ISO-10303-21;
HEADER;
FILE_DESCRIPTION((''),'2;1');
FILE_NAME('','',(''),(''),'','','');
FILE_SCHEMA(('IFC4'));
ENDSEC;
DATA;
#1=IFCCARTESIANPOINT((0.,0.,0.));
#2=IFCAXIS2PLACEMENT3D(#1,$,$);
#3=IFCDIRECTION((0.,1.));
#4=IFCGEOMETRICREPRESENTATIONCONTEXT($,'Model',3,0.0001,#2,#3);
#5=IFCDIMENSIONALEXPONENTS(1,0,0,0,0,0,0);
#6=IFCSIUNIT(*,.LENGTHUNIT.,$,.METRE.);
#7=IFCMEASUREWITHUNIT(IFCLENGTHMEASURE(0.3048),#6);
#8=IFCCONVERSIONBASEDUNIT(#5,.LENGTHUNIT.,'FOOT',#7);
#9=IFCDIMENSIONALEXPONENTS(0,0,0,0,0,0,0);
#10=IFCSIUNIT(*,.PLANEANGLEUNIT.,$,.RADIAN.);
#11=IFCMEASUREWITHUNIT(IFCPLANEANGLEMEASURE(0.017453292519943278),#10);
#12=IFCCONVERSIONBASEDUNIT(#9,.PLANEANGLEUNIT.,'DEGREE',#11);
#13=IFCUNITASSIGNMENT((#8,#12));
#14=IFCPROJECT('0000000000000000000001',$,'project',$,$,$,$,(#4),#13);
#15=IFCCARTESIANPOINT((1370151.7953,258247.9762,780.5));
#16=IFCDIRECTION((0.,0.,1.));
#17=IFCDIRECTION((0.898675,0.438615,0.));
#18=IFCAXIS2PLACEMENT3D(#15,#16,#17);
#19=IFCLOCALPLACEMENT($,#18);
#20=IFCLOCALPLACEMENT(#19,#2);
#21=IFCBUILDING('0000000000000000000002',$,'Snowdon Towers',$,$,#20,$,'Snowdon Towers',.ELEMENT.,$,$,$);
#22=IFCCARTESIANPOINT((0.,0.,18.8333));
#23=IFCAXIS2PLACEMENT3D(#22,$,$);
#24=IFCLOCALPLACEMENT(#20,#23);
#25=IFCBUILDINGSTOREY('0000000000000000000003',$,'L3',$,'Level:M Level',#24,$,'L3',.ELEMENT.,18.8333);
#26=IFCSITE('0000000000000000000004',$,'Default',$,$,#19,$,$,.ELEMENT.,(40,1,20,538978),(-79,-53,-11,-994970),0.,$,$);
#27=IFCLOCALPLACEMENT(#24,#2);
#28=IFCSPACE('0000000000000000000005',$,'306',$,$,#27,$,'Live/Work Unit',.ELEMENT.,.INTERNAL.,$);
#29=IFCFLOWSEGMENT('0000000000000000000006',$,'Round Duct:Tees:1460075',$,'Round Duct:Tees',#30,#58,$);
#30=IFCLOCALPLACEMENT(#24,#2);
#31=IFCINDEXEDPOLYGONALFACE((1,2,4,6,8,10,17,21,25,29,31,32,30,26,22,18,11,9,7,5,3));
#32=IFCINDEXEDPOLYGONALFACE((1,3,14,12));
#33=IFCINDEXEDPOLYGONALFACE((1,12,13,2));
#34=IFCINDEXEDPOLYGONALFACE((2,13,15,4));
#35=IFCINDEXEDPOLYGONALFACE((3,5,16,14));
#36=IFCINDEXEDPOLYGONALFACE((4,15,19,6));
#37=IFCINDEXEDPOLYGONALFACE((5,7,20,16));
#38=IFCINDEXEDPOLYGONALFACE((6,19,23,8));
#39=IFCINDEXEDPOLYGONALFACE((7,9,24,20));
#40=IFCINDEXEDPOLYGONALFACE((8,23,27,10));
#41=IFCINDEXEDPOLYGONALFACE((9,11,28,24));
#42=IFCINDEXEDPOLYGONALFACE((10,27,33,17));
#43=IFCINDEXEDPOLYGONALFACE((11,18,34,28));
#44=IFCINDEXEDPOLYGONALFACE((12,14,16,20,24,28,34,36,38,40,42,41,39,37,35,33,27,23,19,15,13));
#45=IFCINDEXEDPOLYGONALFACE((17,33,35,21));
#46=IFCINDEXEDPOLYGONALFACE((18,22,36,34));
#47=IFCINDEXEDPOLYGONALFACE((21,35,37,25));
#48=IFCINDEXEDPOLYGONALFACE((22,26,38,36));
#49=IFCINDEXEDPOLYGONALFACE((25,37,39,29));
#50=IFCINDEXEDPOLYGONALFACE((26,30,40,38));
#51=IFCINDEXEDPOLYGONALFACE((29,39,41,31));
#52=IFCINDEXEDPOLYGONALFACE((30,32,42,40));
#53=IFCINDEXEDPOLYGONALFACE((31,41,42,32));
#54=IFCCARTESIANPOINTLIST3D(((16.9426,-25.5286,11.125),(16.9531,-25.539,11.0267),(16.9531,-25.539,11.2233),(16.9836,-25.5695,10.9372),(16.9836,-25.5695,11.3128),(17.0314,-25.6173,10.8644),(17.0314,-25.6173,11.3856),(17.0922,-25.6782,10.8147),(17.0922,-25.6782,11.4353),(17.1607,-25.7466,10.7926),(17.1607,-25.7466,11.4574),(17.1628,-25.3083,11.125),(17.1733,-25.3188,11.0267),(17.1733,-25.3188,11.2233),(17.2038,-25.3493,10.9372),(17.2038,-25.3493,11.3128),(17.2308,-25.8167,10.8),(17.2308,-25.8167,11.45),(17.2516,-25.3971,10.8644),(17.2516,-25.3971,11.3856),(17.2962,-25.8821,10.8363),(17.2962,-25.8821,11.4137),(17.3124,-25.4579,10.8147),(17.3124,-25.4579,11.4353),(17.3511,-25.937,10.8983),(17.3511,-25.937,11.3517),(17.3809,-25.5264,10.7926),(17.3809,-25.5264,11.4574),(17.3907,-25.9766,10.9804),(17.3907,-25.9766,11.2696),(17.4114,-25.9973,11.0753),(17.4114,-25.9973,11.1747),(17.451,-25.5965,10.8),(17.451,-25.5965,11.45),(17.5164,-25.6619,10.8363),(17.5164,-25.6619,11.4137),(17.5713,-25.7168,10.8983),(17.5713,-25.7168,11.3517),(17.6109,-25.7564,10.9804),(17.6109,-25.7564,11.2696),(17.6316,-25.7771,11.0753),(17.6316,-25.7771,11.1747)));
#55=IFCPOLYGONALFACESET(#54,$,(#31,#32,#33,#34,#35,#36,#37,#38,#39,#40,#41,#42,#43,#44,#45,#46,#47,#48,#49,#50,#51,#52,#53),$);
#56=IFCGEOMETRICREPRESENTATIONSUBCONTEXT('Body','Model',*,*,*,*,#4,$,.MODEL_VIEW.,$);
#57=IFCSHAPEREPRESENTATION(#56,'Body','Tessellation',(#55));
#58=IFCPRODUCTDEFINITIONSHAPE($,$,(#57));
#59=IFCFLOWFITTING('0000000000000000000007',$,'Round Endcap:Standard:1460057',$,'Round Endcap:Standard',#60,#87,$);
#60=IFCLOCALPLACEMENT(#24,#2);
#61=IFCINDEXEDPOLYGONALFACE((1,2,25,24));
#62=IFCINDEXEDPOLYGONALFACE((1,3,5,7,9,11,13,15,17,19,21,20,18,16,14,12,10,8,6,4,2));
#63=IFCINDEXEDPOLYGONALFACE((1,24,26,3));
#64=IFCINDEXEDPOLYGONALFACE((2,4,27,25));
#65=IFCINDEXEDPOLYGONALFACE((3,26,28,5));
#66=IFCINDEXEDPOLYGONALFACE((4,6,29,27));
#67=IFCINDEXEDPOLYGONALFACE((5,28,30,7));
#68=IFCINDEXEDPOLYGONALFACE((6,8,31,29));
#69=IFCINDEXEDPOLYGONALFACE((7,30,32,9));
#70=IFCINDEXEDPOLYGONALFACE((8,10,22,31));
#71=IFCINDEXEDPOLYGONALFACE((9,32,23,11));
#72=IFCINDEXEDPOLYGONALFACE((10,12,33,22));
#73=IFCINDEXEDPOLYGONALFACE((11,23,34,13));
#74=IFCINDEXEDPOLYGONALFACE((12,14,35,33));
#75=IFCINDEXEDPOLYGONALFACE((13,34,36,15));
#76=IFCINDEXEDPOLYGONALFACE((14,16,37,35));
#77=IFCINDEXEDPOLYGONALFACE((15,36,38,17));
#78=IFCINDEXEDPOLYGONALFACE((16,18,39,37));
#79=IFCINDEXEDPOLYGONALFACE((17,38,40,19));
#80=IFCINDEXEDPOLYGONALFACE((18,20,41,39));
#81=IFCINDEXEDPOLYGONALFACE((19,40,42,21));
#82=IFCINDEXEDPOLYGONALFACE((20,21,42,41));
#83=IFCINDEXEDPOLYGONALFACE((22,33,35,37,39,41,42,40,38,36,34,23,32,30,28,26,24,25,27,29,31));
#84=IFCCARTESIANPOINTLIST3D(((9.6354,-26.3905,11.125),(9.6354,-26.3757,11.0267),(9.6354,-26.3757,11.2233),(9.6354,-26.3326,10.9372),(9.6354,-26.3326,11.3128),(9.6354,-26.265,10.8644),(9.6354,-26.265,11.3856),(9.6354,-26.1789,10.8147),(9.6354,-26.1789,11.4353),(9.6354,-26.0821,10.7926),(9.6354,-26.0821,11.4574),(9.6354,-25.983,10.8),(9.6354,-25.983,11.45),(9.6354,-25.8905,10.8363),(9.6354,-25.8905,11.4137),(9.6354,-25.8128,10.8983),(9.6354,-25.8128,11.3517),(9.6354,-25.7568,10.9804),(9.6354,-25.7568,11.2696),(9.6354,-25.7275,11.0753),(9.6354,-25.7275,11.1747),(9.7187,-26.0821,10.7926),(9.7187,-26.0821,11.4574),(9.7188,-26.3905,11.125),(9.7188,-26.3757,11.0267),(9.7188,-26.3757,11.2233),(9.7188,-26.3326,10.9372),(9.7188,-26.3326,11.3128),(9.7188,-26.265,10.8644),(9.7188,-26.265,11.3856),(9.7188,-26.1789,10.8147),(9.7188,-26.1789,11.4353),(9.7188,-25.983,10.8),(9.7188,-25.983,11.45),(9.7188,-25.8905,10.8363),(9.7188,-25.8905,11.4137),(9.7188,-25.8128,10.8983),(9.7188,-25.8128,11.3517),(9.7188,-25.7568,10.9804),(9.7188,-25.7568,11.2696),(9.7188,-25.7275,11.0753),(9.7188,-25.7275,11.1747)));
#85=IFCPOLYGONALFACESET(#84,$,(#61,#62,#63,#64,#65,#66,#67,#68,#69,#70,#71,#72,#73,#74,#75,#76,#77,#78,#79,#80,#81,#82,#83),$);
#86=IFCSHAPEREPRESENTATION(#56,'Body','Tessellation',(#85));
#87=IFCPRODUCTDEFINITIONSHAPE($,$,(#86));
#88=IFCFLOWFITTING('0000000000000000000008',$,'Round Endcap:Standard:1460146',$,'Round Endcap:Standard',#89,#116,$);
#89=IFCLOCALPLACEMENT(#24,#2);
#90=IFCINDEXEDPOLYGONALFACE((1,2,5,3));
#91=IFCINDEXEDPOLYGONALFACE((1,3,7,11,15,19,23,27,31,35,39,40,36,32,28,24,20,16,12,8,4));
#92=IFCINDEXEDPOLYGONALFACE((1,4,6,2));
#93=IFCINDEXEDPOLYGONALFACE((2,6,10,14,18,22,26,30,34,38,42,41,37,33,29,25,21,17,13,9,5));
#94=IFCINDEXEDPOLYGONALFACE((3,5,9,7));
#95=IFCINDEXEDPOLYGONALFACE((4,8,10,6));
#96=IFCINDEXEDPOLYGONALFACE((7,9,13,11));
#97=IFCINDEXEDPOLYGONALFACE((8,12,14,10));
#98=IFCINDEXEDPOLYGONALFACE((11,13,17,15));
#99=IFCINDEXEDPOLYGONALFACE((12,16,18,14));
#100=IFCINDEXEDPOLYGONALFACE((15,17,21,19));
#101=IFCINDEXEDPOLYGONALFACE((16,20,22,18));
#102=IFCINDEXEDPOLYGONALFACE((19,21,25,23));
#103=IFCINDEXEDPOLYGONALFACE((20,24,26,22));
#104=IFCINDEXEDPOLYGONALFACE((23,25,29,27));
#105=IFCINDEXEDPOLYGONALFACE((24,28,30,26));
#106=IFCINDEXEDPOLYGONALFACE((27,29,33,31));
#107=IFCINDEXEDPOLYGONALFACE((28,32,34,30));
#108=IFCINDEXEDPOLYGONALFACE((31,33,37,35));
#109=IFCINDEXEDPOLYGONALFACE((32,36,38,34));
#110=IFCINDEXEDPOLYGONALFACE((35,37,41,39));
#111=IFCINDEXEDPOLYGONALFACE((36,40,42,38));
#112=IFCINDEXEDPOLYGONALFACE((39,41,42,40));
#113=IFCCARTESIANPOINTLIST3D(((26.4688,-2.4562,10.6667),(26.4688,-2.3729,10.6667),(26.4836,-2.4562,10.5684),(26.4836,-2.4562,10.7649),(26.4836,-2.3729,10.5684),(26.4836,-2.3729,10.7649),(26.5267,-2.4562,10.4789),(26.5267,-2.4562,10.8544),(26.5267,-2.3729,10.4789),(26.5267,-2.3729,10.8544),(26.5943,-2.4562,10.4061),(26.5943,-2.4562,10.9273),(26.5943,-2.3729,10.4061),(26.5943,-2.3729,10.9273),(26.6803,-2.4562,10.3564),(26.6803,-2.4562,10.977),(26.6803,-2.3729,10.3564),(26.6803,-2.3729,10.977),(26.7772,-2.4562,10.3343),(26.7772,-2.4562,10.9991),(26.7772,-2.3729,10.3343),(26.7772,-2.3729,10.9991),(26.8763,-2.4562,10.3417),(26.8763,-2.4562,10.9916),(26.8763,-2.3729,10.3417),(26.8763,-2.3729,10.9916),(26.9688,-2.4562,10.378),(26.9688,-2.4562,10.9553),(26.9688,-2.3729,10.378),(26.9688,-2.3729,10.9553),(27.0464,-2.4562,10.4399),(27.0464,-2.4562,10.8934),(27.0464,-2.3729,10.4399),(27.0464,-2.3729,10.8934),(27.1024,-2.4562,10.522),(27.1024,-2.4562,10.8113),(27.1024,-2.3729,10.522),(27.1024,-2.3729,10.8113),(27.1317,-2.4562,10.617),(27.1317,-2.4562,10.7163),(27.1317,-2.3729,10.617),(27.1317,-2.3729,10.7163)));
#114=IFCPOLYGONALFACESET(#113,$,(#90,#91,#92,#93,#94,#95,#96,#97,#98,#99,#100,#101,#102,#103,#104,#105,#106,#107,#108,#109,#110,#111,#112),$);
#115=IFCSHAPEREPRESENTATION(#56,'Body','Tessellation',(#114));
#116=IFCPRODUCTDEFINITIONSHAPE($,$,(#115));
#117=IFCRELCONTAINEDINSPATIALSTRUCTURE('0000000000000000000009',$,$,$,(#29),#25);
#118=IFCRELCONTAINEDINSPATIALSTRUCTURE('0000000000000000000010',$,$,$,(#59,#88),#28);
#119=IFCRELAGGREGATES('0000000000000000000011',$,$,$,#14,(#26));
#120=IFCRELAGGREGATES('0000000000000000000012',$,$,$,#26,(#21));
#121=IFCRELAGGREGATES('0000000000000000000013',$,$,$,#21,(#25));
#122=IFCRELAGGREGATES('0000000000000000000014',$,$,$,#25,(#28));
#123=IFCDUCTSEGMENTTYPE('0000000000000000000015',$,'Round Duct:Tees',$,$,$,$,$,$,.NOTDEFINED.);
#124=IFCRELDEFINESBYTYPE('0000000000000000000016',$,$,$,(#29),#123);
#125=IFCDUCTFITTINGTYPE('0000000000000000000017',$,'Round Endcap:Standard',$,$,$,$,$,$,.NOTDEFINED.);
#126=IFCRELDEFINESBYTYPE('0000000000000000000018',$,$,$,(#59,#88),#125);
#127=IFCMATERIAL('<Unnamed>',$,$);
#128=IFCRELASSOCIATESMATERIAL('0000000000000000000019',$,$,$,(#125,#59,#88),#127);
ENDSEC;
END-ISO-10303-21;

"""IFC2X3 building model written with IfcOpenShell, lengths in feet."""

from ifc_helpers import new_model, entity, si_unit, converted_unit, direction, frame, frame_2d, origin, origin_2d_with_axis, place, context, subcontext, project, spatial, circle, extrude, source, transform, mapped, material, type_object, type_shapes, element, save


model = new_model("IFC2X3")

# Units and contexts
model_context = context("Model", 3, precision=0.0001, world=origin(), true_north=direction((0.0, 1.0)))
body_context = subcontext(model_context, "Body", "Model", "MODEL_VIEW")
ifc_project = project(units=[converted_unit("LENGTHUNIT", "FOOT", entity("IfcLengthMeasure", 0.3048), si_unit("LENGTHUNIT", "METRE"), dimensions=[1, 0, 0, 0, 0, 0, 0]), converted_unit("PLANEANGLEUNIT", "DEGREE", entity("IfcPlaneAngleMeasure", 0.017453292519943278), si_unit("PLANEANGLEUNIT", "RADIAN"), dimensions=[0, 0, 0, 0, 0, 0, 0])], contexts=[model_context])

# Site, building, storey
site_placement = place(None, frame((1370151.7953, 258247.9762, 780.5), z_axis=(0.0, 0.0, 1.0), x_axis=(0.898675, 0.438615, 0.0)))
site = spatial("IfcSite", under=ifc_project, at=site_placement, Name="Default", CompositionType="ELEMENT", RefLatitude=(40, 1, 20, 538978), RefLongitude=(-79, -53, -11, -994970), RefElevation=0.0)
building_placement = place(site_placement, origin())
building = spatial("IfcBuilding", under=site, at=building_placement, Name="Snowdon Towers", LongName="Snowdon Towers", CompositionType="ELEMENT")
storey_placement = place(building_placement, frame((0.0, 0.0, 18.8333)))
storey = spatial("IfcBuildingStorey", under=building, at=storey_placement, Name="L3", ObjectType="Level:M Level", LongName="L3", CompositionType="ELEMENT", Elevation=18.8333)

# Flow segment
duct_segment_type = type_object("IfcDuctSegmentType", Name="Round Duct:Tees", PredefinedType="NOTDEFINED")
flow_segment_1_placement = place(storey_placement, frame((16.9374, -26.0052, 10.7864)))
element("IfcFlowSegment", 1, at=flow_segment_1_placement, inside=storey, type_object=duct_segment_type, Name="Round Duct:Tees:1460075", ObjectType="Round Duct:Tees", context=body_context, shape_type="SweptSolid", body=[
    extrude(circle(Radius=0.3333, at=origin_2d_with_axis()), frame((0.2409, 0.2409, 0.3386), z_axis=(0.707107, 0.707107, 0.0), x_axis=(-0.707107, 0.707107, 0.0)), (0.0, 0.0, 1.0), 0.3114),
])

# Shared definitions
space_placement = place(storey_placement, origin())
space = spatial("IfcSpace", under=storey, at=space_placement, Name="306", LongName="Live/Work Unit", CompositionType="ELEMENT", InteriorOrExteriorSpace="INTERNAL")

# Flow fittings
ifc_material = material(Name="<Unnamed>")
duct_fitting_type = type_object("IfcDuctFittingType", Name="Round Endcap:Standard", PredefinedType="NOTDEFINED", material=ifc_material)
shared_shape_1 = source(origin(), body_context, "Body", "SweptSolid", [
    extrude(circle(Radius=0.3333, at=frame_2d((0.0, 0.0), x_axis=(1.0, 0.0))), frame((0.0, 0.0, 0.0), z_axis=(1.0, 0.0, 0.0), x_axis=(0.0, 1.0, 0.0)), (0.0, 0.0, 1.0), 0.0833),
])
type_shapes(duct_fitting_type, [shared_shape_1])
for number, where, z_axis, x_axis, name in (
    (2, (9.7188, -26.0572, 11.125), (0.0, 0.0, 1.0), (-1.0, 0.0, 0.0), "Round Endcap:Standard:1460057"),
    (3, (26.8021, -2.4562, 10.6667), (0.0, 0.0, 1.0), (0.0, 1.0, 0.0), "Round Endcap:Standard:1460146"),
):
    element("IfcFlowFitting", number, at=place(space_placement, frame(where, z_axis=z_axis, x_axis=x_axis)), inside=space, type_object=duct_fitting_type, material=ifc_material, Name=name, ObjectType="Round Endcap:Standard", context=body_context, shape_type="MappedRepresentation", body=[
        mapped(shared_shape_1, transform((0.0, 0.0, 0.0), scale=1.0)),
    ])

save(model, "model.ifc")
